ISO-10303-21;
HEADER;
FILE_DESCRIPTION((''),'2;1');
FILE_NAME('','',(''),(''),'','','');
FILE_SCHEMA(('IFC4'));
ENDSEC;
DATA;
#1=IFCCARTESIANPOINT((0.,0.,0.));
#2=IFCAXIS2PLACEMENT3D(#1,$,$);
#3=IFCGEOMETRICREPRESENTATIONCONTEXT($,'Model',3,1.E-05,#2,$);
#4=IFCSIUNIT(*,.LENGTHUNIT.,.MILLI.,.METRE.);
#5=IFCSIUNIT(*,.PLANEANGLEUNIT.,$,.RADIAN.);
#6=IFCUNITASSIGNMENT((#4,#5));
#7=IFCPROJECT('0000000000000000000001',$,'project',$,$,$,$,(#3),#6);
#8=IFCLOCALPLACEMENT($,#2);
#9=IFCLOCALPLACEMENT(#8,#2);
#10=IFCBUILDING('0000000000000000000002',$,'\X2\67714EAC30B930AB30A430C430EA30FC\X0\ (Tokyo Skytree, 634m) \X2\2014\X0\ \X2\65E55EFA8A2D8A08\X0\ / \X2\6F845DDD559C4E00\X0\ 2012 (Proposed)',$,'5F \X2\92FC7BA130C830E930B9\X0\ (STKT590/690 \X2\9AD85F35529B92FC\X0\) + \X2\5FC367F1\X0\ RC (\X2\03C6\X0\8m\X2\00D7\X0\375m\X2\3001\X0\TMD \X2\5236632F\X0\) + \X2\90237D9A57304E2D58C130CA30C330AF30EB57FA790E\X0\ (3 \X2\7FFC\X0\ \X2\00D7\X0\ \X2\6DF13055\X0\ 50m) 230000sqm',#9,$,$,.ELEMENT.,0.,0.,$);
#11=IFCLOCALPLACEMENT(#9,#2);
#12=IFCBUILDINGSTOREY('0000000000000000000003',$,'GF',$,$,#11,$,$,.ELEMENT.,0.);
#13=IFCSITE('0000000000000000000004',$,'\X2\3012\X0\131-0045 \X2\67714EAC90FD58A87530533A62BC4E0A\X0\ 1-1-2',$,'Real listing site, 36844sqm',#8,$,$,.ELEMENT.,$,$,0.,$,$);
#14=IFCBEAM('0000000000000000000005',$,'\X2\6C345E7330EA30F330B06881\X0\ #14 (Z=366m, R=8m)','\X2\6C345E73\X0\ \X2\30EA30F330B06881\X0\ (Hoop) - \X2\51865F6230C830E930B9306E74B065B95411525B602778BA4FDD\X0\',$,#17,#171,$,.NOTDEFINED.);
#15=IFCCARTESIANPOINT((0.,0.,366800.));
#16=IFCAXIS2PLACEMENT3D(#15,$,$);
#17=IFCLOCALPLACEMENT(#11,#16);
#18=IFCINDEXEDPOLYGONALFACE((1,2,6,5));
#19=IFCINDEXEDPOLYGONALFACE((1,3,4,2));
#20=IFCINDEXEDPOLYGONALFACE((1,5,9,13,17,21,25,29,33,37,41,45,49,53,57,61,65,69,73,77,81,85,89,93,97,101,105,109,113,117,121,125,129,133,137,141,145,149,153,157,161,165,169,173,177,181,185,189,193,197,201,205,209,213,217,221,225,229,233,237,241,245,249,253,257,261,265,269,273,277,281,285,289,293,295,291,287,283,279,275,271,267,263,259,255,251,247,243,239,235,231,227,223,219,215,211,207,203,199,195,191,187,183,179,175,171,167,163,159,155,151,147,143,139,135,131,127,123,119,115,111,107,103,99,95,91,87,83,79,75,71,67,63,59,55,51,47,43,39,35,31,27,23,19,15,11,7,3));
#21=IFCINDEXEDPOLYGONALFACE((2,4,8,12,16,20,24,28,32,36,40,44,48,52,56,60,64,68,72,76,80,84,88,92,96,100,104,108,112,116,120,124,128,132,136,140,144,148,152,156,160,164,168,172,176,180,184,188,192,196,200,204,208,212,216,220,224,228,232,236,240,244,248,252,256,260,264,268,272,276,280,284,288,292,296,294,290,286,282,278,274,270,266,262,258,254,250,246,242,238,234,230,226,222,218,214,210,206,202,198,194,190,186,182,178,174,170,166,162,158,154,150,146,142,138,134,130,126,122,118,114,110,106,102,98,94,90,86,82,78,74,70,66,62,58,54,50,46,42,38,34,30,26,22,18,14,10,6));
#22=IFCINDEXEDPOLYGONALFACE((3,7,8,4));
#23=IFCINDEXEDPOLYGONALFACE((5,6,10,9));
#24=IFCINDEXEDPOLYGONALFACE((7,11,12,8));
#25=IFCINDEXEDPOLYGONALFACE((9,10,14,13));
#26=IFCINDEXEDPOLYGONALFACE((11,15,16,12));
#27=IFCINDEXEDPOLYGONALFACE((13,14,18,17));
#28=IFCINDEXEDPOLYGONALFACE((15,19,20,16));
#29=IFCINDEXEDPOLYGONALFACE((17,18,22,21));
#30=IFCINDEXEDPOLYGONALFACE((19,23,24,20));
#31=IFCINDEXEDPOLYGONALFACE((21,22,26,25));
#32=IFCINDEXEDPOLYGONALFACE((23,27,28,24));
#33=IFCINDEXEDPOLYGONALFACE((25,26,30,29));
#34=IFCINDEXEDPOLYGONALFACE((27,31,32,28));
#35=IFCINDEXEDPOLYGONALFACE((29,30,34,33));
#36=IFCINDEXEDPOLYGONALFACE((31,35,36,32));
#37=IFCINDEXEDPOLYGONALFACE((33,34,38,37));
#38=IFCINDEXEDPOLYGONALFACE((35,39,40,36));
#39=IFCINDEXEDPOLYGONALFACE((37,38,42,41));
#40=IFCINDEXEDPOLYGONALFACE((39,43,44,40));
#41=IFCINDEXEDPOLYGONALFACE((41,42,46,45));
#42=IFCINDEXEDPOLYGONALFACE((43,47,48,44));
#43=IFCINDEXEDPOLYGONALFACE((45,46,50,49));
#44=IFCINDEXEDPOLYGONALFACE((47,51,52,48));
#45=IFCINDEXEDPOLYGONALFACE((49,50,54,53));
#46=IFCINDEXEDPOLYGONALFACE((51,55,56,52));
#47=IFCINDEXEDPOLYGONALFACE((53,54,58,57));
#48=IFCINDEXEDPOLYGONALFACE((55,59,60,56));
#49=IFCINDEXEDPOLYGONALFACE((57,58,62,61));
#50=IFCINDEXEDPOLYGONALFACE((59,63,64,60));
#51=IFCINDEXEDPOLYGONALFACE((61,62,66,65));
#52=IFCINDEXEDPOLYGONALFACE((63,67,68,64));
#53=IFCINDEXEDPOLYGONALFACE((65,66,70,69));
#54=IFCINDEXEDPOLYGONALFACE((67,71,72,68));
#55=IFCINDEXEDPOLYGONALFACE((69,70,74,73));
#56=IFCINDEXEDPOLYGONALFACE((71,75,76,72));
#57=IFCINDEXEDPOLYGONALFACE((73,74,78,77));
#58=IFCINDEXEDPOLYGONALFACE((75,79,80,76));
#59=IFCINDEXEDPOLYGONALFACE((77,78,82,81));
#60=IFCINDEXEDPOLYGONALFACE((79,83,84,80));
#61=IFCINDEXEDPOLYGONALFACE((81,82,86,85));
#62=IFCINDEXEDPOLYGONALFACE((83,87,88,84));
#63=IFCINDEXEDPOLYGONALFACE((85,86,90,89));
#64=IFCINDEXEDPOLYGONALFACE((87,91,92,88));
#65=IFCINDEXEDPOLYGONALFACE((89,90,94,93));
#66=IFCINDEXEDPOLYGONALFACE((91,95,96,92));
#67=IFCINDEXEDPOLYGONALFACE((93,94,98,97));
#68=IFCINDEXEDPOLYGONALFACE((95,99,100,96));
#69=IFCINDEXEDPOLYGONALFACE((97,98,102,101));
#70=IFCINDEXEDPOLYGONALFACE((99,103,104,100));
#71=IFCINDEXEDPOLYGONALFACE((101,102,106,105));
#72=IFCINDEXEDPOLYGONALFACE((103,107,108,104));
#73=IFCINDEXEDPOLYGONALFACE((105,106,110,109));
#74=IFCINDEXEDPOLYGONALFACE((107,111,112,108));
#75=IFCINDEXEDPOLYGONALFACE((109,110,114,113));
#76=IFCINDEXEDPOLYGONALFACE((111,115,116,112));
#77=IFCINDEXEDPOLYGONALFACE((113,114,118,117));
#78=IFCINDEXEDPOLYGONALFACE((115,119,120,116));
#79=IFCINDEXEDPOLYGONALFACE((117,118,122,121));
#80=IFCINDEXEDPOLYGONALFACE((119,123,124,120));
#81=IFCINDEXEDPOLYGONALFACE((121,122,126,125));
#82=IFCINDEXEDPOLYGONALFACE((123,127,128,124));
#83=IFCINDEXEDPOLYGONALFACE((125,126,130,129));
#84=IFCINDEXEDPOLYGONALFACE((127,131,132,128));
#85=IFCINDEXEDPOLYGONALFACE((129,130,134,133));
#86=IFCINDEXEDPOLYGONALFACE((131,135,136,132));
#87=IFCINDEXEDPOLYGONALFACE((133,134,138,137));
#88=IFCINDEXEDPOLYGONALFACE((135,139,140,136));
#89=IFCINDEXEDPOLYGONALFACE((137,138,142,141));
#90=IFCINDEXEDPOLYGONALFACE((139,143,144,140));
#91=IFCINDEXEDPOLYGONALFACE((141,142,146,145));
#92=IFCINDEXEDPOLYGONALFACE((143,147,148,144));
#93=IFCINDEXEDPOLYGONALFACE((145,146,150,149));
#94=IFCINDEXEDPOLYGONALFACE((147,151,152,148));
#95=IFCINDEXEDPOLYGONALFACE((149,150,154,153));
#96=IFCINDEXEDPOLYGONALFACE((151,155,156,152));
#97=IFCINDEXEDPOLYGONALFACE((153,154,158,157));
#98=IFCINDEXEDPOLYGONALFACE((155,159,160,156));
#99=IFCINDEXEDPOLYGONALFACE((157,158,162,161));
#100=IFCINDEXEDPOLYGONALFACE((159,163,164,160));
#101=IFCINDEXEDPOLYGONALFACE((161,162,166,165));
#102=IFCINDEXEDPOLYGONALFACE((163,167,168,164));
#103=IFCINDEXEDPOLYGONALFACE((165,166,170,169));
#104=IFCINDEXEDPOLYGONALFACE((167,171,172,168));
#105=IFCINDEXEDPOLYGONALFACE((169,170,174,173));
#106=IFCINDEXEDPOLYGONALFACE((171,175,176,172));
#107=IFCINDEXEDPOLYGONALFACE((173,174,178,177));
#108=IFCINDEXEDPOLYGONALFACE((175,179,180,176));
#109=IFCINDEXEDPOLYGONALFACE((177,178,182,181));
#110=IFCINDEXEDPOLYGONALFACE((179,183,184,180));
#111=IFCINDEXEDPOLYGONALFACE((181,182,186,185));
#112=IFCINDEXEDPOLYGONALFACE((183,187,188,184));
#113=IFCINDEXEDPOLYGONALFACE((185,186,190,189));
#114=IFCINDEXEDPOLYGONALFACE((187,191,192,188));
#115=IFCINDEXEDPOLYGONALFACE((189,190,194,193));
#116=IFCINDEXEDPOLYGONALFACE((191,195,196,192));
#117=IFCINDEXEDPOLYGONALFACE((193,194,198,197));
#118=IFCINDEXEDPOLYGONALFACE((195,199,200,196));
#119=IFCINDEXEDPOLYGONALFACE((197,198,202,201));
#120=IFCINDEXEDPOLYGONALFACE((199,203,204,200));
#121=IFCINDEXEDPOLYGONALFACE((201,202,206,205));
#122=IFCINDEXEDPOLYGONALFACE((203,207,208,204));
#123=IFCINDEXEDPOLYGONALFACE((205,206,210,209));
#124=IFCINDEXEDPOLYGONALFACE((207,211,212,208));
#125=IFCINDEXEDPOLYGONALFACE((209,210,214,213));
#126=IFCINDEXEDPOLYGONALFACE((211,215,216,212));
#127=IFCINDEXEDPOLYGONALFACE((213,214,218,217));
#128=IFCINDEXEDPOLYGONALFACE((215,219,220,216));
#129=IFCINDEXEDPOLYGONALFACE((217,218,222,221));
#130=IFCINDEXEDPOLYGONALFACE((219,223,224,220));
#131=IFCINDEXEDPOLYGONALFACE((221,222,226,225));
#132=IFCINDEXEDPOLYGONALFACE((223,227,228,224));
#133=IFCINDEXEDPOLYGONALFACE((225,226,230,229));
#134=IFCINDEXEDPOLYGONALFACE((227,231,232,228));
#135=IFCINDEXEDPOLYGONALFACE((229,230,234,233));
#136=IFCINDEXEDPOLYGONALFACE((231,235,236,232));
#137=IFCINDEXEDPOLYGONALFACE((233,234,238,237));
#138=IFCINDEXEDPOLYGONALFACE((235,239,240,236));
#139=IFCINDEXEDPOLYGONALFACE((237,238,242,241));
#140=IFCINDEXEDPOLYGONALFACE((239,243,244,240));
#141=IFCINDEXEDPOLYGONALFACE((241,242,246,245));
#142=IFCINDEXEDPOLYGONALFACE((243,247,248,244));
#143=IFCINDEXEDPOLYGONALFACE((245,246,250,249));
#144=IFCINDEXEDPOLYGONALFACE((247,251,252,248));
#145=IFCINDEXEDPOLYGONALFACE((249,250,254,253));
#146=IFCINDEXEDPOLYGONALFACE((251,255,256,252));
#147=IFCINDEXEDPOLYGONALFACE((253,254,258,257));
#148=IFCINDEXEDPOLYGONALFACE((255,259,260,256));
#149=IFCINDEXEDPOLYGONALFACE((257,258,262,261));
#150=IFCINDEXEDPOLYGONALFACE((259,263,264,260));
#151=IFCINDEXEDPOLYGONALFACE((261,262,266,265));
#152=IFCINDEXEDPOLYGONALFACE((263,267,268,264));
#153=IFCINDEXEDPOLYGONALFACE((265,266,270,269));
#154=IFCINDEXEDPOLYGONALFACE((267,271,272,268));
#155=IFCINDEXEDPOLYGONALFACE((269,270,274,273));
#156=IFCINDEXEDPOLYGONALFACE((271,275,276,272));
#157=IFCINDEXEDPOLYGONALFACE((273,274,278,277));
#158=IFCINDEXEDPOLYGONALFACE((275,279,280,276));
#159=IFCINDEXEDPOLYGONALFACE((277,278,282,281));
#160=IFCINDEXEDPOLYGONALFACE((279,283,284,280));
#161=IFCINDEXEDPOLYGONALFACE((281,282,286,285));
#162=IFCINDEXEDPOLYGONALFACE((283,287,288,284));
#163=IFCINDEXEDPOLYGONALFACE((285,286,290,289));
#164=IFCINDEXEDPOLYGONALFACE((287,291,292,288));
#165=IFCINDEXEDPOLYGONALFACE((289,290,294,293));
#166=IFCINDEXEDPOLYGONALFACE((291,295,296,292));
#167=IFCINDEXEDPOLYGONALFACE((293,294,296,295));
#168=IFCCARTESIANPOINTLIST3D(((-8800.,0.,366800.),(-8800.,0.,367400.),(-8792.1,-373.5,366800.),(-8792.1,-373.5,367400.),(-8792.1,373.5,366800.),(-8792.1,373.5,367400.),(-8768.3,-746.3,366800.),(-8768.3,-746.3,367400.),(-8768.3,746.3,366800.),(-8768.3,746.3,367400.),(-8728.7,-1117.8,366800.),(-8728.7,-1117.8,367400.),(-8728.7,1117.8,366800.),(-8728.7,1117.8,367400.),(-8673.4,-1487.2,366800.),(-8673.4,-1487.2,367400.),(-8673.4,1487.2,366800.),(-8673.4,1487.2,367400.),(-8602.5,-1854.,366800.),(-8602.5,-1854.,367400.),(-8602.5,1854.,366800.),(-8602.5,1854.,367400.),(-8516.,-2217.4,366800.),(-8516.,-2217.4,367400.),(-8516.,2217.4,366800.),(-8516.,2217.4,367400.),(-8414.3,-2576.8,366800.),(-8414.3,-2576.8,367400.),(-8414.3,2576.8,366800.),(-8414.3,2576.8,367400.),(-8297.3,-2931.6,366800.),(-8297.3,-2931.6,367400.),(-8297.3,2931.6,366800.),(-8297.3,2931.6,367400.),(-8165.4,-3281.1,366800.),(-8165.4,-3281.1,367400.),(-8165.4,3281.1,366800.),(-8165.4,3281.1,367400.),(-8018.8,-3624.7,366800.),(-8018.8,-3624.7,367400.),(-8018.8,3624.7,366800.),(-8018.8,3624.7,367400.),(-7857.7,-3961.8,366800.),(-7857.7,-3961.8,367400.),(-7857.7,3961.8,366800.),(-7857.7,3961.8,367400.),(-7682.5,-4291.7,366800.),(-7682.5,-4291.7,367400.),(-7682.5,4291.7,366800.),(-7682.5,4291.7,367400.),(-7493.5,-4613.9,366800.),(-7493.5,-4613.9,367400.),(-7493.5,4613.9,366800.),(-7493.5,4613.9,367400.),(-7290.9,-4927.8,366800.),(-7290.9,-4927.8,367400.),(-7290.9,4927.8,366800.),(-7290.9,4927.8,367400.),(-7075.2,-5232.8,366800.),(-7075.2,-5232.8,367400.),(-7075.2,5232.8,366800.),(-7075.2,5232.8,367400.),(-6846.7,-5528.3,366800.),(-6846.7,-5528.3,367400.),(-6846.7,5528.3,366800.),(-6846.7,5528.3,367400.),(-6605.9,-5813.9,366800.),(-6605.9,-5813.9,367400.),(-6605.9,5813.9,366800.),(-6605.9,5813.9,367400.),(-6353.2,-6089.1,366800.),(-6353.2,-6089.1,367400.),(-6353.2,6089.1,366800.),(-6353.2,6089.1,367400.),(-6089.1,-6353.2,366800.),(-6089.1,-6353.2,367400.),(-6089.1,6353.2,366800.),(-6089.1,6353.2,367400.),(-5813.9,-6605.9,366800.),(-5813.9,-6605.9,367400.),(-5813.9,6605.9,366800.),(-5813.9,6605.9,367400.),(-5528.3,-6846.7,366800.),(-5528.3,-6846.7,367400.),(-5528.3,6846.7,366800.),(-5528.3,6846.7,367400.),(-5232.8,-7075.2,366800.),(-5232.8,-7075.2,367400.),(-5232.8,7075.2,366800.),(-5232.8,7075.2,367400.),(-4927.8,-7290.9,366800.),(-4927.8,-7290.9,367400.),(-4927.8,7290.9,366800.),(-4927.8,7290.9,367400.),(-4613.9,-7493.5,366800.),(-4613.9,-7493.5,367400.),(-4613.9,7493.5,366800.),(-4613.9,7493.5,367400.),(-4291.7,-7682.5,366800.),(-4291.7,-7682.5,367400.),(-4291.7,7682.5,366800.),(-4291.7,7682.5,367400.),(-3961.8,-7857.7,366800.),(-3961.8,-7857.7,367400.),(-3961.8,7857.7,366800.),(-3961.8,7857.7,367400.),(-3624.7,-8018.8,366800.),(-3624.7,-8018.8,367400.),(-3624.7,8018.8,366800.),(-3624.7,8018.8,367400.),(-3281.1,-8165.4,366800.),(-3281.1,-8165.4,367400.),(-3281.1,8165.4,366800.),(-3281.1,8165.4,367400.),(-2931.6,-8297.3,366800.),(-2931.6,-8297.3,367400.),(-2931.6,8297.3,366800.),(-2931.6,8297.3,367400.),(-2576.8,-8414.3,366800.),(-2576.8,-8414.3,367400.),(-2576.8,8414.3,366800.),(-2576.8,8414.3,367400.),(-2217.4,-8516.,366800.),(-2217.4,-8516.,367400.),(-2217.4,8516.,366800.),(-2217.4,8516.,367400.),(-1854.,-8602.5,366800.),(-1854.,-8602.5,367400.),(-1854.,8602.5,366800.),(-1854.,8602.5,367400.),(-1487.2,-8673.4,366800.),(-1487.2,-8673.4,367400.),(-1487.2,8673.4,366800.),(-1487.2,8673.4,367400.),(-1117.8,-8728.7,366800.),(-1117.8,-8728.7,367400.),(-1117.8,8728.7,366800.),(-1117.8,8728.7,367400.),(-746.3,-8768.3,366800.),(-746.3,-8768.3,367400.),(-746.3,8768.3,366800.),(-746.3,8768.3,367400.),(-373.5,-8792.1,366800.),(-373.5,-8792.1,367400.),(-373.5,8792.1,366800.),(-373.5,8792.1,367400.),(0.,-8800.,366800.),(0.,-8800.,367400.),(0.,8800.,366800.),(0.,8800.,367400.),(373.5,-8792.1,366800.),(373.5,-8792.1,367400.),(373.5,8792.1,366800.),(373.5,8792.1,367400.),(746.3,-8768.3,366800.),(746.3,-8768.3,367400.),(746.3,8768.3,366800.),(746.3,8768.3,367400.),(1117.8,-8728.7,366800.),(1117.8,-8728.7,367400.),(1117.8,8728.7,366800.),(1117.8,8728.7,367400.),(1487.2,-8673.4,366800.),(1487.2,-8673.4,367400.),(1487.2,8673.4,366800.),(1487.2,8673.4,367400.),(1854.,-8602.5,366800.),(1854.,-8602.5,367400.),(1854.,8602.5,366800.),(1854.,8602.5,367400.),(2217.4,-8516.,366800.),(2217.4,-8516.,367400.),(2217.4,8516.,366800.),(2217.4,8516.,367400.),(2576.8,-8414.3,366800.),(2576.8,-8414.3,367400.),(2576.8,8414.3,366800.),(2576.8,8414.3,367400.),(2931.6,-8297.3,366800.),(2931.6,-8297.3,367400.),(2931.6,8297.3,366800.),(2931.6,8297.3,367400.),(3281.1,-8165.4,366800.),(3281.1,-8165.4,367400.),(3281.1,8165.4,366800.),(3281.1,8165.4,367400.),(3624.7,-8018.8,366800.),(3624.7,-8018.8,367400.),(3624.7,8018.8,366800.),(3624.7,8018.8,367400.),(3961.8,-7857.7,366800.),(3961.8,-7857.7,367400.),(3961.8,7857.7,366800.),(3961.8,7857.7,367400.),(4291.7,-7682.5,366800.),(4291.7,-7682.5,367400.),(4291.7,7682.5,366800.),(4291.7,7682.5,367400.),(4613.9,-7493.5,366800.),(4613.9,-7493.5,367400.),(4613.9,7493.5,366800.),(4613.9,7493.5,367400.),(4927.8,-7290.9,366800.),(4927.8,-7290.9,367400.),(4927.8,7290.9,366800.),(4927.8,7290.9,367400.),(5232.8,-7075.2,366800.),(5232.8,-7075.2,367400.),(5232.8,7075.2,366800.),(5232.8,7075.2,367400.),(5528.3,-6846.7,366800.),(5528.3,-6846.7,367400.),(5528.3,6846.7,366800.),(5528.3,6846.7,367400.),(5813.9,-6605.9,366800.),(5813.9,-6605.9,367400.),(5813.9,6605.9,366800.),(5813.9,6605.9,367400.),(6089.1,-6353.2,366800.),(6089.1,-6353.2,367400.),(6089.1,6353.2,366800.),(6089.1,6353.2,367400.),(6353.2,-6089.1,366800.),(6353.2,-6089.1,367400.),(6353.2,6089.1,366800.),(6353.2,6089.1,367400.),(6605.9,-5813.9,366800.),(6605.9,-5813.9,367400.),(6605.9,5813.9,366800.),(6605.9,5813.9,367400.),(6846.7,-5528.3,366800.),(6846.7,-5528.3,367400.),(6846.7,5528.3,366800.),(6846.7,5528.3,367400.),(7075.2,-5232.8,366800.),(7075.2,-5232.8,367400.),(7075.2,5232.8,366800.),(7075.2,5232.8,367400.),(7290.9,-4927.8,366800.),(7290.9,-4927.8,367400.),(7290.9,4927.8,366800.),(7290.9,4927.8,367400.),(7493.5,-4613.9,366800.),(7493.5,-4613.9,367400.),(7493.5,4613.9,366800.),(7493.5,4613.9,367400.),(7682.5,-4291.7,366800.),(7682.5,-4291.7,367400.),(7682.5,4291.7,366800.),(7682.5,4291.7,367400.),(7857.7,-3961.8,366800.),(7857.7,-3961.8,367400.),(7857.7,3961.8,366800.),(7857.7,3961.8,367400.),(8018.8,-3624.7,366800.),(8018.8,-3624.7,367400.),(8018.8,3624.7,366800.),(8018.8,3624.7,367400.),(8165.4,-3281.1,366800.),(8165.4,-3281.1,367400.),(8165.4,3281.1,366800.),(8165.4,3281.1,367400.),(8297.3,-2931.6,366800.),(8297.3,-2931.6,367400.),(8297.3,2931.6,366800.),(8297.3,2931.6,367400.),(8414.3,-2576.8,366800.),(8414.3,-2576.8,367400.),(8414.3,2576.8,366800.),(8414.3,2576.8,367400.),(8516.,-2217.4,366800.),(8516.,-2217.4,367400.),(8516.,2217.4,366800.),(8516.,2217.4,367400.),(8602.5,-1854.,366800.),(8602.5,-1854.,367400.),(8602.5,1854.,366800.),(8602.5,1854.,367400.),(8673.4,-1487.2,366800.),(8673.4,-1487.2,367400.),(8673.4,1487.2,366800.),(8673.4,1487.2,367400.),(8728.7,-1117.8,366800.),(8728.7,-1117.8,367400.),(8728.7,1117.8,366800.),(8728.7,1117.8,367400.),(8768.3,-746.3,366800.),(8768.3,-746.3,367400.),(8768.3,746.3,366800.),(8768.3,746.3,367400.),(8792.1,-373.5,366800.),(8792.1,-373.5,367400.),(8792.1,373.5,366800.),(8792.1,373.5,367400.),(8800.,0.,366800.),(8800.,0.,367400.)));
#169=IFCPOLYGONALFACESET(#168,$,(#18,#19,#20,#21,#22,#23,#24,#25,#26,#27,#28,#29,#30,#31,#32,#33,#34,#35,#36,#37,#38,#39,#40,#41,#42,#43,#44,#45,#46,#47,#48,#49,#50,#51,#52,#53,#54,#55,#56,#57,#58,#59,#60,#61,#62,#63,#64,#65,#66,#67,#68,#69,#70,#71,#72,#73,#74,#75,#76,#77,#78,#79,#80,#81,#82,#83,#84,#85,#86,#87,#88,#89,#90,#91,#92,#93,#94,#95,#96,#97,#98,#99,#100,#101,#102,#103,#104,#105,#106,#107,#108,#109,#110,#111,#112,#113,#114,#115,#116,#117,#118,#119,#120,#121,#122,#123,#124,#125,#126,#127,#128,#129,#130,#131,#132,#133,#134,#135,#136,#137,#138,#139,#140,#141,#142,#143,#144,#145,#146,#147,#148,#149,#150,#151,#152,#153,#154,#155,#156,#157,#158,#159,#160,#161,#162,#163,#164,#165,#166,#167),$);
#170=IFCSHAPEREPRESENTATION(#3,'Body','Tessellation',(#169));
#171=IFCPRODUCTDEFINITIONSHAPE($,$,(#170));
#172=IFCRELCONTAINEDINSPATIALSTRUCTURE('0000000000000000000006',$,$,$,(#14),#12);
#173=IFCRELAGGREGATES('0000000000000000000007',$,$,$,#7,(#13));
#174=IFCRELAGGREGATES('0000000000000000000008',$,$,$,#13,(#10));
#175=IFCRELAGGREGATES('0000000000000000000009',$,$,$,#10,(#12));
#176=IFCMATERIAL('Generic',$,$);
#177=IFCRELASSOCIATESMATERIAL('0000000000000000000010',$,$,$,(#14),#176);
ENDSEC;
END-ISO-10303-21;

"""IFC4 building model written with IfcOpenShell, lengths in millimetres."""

from ifc_helpers import new_model, si_unit, frame, origin, origin_2d, place, context, project, spatial, circle, extrude, material, element, save


model = new_model("IFC4")

# Units and contexts
model_context = context("Model", 3, precision=1e-05, world=origin())
ifc_project = project(units=[si_unit("LENGTHUNIT", "METRE", prefix="MILLI"), si_unit("PLANEANGLEUNIT", "RADIAN")], contexts=[model_context])

# Site, building, storey
site_placement = place(None, origin())
site = spatial("IfcSite", under=ifc_project, at=site_placement, Name="〒131-0045 東京都墨田区押上 1-1-2", ObjectType="Real listing site, 36844sqm", CompositionType="ELEMENT", RefElevation=0.0)
building_placement = place(site_placement, origin())
building = spatial("IfcBuilding", under=site, at=building_placement, Name="東京スカイツリー (Tokyo Skytree, 634m) — 日建設計 / 澄川喜一 2012 (Proposed)", ObjectType="5F 鋼管トラス (STKT590/690 高張力鋼) + 心柱 RC (φ8m×375m、TMD 制振) + 連続地中壁ナックル基礎 (3 翼 × 深さ 50m) 230000sqm", CompositionType="ELEMENT", ElevationOfRefHeight=0.0, ElevationOfTerrain=0.0)
storey_placement = place(building_placement, origin())
storey = spatial("IfcBuildingStorey", under=building, at=storey_placement, Name="GF", CompositionType="ELEMENT", Elevation=0.0)

# Shared definitions
ifc_material_1 = material(Name="Generic")

# Beam
beam_1_placement = place(storey_placement, frame((0.0, 0.0, 366800.0)))
element("IfcBeam", 1, at=beam_1_placement, inside=storey, material=ifc_material_1, Name="水平リング梁 #14 (Z=366m, R=8m)", Description="水平 リング梁 (Hoop) - 円形トラスの環方向剛性確保", PredefinedType="NOTDEFINED", context=model_context, shape_type="SweptSolid", body=[
    extrude(circle(Radius=8800.0, at=origin_2d()), frame((0.0, 0.0, 366800.0)), (0.0, 0.0, 1.0), 600.0),
])

save(model, "model.ifc")
